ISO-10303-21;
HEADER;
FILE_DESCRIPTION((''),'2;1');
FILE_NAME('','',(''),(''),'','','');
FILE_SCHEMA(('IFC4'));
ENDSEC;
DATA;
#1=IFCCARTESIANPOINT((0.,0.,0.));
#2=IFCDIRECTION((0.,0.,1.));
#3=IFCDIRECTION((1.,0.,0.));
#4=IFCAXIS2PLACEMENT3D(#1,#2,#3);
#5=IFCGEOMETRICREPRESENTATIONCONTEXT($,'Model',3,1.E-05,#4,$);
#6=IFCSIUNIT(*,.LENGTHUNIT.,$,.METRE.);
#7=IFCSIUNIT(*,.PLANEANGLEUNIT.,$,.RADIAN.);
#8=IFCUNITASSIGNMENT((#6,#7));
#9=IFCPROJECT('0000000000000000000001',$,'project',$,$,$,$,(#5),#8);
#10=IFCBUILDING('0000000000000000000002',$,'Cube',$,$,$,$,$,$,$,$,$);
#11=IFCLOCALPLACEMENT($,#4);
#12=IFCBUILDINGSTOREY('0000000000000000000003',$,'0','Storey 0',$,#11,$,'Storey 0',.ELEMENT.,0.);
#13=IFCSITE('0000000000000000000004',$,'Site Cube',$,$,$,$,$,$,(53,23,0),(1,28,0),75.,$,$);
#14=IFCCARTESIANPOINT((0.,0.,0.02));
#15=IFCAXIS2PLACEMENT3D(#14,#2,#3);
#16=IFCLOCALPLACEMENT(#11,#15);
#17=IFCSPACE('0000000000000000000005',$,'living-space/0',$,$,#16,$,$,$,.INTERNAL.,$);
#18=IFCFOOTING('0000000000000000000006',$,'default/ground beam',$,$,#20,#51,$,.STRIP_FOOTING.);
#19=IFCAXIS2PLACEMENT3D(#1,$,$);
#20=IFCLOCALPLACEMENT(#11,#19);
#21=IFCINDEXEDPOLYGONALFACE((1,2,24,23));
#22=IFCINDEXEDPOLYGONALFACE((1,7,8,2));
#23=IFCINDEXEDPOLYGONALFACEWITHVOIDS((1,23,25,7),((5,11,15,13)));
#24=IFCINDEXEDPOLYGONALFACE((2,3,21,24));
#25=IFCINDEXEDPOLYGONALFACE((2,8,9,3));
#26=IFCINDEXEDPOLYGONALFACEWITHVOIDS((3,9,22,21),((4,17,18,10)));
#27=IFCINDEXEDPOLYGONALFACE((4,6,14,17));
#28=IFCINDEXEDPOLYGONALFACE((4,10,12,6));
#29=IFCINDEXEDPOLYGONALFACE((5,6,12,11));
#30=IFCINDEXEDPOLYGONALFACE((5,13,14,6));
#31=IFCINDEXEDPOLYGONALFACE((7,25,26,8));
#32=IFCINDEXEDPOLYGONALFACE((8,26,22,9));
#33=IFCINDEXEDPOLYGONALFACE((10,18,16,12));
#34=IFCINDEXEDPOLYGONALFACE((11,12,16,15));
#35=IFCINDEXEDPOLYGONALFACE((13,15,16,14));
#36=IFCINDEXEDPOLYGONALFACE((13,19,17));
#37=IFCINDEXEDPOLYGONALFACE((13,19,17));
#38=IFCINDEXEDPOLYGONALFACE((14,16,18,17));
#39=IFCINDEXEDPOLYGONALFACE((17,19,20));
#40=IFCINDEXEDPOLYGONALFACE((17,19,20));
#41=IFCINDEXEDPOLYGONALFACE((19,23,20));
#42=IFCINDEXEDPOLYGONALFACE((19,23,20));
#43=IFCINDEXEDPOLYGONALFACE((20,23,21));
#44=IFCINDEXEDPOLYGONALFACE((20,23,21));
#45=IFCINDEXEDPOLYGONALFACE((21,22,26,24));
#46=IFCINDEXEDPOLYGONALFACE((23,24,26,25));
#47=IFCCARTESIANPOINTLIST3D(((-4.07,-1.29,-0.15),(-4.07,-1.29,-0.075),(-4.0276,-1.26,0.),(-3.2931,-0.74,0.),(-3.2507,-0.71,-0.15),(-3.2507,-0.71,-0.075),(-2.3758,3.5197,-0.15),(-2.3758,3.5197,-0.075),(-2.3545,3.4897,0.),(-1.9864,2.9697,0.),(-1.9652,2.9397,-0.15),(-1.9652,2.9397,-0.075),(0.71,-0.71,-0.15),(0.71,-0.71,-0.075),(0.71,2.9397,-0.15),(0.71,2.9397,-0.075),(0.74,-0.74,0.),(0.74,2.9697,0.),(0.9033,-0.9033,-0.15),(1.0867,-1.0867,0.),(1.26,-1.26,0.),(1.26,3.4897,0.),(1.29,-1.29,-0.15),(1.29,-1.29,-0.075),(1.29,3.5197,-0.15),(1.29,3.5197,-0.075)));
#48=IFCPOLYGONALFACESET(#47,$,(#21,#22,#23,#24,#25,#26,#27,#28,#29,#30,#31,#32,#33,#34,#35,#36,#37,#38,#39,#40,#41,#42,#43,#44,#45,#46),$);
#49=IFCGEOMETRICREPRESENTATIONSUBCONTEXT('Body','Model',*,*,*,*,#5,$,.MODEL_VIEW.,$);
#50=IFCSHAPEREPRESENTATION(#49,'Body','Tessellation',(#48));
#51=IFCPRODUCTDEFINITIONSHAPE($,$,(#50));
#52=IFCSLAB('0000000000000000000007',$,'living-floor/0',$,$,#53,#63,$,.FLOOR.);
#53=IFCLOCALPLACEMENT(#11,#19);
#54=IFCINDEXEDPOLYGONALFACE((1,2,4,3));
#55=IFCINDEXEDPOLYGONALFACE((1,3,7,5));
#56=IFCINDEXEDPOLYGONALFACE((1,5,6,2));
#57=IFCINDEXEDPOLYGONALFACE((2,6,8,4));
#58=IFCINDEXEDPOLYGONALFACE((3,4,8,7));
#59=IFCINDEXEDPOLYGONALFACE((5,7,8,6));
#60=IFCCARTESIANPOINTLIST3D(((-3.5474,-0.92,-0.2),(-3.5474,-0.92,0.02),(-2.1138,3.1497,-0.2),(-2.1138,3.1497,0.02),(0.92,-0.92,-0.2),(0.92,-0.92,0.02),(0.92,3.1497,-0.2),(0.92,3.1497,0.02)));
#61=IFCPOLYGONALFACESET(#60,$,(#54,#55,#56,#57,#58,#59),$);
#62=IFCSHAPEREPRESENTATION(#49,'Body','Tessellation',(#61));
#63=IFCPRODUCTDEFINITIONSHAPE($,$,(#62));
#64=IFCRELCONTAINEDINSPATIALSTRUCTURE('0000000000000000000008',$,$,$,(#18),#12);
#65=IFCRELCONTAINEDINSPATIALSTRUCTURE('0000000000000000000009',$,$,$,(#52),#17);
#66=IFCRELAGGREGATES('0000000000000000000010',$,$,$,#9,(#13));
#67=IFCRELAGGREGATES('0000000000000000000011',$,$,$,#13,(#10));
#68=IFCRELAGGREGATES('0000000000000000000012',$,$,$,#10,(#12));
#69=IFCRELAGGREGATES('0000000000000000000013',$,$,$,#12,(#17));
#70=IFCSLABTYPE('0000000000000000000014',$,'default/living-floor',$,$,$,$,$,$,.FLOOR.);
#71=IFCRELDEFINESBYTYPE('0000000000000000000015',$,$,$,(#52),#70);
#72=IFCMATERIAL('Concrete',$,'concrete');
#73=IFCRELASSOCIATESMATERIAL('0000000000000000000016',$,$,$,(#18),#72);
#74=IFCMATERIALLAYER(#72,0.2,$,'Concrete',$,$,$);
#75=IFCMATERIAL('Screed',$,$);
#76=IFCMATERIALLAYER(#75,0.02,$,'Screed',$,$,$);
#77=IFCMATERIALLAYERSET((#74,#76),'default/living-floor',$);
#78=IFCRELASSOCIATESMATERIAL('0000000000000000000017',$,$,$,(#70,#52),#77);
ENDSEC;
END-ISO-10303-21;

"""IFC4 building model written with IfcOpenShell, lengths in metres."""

from ifc_helpers import new_model, entity, si_unit, frame, origin, origin_with_axes, place, context, subcontext, project, spatial, polyline, outline, extrude, material, layer, layer_set, layer_usage, type_object, element, save


model = new_model("IFC4")

# Units and contexts
model_context = context("Model", 3, precision=1e-05, world=origin_with_axes())
body_context = subcontext(model_context, "Body", "Model", "MODEL_VIEW")
ifc_project = project(units=[si_unit("LENGTHUNIT", "METRE"), si_unit("PLANEANGLEUNIT", "RADIAN")], contexts=[model_context])

# Site, building, storey
site = spatial("IfcSite", under=ifc_project, Name="Site Cube", RefLatitude=(53, 23, 0), RefLongitude=(1, 28, 0), RefElevation=75.0)
building = spatial("IfcBuilding", under=site, Name="Cube")
storey_placement = place(None, origin_with_axes())
storey = spatial("IfcBuildingStorey", under=building, at=storey_placement, Name="0", Description="Storey 0", LongName="Storey 0", CompositionType="ELEMENT", Elevation=0.0)

# Footing
ifc_material_1 = material(Name="Concrete", Category="concrete")
footing_placement = place(storey_placement, origin_with_axes())
axis2_placement3_d = entity("IfcAxis2Placement3D", entity("IfcCartesianPoint", [0.0, 0.0, 0.0]))
element("IfcFooting", 1, at=footing_placement, inside=storey, material=ifc_material_1, Name="default/ground beam", PredefinedType="STRIP_FOOTING", context=body_context, shape_type="AdvancedSweptSolid", body=[
    entity("IfcSurfaceCurveSweptAreaSolid", entity("IfcDerivedProfileDef", "AREA", None, entity("IfcArbitraryClosedProfileDef", "AREA", None, entity("IfcPolyline", [entity("IfcCartesianPoint", [0.0, -0.26]), entity("IfcCartesianPoint", [-0.075, -0.29]), entity("IfcCartesianPoint", [-0.15, -0.29]), entity("IfcCartesianPoint", [-0.15, 0.29]), entity("IfcCartesianPoint", [-0.075, 0.29]), entity("IfcCartesianPoint", [0.0, 0.26]), entity("IfcCartesianPoint", [0.0, -0.26])])), entity("IfcCartesianTransformationOperator2D", None, None, entity("IfcCartesianPoint", [0.0, 0.0]), 1.0)), axis2_placement3_d, entity("IfcPolyline", [entity("IfcCartesianPoint", [1.0, -1.0]), entity("IfcCartesianPoint", [1.0, 3.2297]), entity("IfcCartesianPoint", [-2.1705, 3.2297]), entity("IfcCartesianPoint", [-3.6604, -1.0]), entity("IfcCartesianPoint", [1.0, -1.0])]), 0.0, 1.0, entity("IfcPlane", axis2_placement3_d)),
])

# Shared definitions
space_placement = place(storey_placement, frame((0.0, 0.0, 0.02), z_axis=(0.0, 0.0, 1.0), x_axis=(1.0, 0.0, 0.0)))
space = spatial("IfcSpace", under=storey, at=space_placement, Name="living-space/0", PredefinedType="INTERNAL")

# Slab
ifc_layer_1 = layer(ifc_material_1, 0.2, Name="Concrete")
ifc_material_2 = material(Name="Screed")
ifc_layer_2 = layer(ifc_material_2, 0.02, Name="Screed")
ifc_layer_set_1 = layer_set([ifc_layer_1, ifc_layer_2], Name="default/living-floor")
ifc_layer_usage_1 = layer_usage(ifc_layer_set_1, "AXIS3", "POSITIVE", -0.2)
slab_type = type_object("IfcSlabType", Name="default/living-floor", PredefinedType="FLOOR", material=ifc_layer_set_1)
slab_placement = place(space_placement, frame((0.0, 0.0, -0.22), z_axis=(0.0, 0.0, 1.0), x_axis=(1.0, 0.0, 0.0)))
element("IfcSlab", 2, at=slab_placement, inside=space, type_object=slab_type, material=ifc_layer_usage_1, Name="living-floor/0", PredefinedType="FLOOR", context=body_context, shape_type="SweptSolid", body=[
    extrude(outline(polyline([(-3.5474, -0.92), (0.92, -0.92), (0.92, 3.1497), (-2.1138, 3.1497), (-3.5474, -0.92)])), origin(), (0.0, 0.0, 1.0), 0.22),
])

save(model, "model.ifc")
